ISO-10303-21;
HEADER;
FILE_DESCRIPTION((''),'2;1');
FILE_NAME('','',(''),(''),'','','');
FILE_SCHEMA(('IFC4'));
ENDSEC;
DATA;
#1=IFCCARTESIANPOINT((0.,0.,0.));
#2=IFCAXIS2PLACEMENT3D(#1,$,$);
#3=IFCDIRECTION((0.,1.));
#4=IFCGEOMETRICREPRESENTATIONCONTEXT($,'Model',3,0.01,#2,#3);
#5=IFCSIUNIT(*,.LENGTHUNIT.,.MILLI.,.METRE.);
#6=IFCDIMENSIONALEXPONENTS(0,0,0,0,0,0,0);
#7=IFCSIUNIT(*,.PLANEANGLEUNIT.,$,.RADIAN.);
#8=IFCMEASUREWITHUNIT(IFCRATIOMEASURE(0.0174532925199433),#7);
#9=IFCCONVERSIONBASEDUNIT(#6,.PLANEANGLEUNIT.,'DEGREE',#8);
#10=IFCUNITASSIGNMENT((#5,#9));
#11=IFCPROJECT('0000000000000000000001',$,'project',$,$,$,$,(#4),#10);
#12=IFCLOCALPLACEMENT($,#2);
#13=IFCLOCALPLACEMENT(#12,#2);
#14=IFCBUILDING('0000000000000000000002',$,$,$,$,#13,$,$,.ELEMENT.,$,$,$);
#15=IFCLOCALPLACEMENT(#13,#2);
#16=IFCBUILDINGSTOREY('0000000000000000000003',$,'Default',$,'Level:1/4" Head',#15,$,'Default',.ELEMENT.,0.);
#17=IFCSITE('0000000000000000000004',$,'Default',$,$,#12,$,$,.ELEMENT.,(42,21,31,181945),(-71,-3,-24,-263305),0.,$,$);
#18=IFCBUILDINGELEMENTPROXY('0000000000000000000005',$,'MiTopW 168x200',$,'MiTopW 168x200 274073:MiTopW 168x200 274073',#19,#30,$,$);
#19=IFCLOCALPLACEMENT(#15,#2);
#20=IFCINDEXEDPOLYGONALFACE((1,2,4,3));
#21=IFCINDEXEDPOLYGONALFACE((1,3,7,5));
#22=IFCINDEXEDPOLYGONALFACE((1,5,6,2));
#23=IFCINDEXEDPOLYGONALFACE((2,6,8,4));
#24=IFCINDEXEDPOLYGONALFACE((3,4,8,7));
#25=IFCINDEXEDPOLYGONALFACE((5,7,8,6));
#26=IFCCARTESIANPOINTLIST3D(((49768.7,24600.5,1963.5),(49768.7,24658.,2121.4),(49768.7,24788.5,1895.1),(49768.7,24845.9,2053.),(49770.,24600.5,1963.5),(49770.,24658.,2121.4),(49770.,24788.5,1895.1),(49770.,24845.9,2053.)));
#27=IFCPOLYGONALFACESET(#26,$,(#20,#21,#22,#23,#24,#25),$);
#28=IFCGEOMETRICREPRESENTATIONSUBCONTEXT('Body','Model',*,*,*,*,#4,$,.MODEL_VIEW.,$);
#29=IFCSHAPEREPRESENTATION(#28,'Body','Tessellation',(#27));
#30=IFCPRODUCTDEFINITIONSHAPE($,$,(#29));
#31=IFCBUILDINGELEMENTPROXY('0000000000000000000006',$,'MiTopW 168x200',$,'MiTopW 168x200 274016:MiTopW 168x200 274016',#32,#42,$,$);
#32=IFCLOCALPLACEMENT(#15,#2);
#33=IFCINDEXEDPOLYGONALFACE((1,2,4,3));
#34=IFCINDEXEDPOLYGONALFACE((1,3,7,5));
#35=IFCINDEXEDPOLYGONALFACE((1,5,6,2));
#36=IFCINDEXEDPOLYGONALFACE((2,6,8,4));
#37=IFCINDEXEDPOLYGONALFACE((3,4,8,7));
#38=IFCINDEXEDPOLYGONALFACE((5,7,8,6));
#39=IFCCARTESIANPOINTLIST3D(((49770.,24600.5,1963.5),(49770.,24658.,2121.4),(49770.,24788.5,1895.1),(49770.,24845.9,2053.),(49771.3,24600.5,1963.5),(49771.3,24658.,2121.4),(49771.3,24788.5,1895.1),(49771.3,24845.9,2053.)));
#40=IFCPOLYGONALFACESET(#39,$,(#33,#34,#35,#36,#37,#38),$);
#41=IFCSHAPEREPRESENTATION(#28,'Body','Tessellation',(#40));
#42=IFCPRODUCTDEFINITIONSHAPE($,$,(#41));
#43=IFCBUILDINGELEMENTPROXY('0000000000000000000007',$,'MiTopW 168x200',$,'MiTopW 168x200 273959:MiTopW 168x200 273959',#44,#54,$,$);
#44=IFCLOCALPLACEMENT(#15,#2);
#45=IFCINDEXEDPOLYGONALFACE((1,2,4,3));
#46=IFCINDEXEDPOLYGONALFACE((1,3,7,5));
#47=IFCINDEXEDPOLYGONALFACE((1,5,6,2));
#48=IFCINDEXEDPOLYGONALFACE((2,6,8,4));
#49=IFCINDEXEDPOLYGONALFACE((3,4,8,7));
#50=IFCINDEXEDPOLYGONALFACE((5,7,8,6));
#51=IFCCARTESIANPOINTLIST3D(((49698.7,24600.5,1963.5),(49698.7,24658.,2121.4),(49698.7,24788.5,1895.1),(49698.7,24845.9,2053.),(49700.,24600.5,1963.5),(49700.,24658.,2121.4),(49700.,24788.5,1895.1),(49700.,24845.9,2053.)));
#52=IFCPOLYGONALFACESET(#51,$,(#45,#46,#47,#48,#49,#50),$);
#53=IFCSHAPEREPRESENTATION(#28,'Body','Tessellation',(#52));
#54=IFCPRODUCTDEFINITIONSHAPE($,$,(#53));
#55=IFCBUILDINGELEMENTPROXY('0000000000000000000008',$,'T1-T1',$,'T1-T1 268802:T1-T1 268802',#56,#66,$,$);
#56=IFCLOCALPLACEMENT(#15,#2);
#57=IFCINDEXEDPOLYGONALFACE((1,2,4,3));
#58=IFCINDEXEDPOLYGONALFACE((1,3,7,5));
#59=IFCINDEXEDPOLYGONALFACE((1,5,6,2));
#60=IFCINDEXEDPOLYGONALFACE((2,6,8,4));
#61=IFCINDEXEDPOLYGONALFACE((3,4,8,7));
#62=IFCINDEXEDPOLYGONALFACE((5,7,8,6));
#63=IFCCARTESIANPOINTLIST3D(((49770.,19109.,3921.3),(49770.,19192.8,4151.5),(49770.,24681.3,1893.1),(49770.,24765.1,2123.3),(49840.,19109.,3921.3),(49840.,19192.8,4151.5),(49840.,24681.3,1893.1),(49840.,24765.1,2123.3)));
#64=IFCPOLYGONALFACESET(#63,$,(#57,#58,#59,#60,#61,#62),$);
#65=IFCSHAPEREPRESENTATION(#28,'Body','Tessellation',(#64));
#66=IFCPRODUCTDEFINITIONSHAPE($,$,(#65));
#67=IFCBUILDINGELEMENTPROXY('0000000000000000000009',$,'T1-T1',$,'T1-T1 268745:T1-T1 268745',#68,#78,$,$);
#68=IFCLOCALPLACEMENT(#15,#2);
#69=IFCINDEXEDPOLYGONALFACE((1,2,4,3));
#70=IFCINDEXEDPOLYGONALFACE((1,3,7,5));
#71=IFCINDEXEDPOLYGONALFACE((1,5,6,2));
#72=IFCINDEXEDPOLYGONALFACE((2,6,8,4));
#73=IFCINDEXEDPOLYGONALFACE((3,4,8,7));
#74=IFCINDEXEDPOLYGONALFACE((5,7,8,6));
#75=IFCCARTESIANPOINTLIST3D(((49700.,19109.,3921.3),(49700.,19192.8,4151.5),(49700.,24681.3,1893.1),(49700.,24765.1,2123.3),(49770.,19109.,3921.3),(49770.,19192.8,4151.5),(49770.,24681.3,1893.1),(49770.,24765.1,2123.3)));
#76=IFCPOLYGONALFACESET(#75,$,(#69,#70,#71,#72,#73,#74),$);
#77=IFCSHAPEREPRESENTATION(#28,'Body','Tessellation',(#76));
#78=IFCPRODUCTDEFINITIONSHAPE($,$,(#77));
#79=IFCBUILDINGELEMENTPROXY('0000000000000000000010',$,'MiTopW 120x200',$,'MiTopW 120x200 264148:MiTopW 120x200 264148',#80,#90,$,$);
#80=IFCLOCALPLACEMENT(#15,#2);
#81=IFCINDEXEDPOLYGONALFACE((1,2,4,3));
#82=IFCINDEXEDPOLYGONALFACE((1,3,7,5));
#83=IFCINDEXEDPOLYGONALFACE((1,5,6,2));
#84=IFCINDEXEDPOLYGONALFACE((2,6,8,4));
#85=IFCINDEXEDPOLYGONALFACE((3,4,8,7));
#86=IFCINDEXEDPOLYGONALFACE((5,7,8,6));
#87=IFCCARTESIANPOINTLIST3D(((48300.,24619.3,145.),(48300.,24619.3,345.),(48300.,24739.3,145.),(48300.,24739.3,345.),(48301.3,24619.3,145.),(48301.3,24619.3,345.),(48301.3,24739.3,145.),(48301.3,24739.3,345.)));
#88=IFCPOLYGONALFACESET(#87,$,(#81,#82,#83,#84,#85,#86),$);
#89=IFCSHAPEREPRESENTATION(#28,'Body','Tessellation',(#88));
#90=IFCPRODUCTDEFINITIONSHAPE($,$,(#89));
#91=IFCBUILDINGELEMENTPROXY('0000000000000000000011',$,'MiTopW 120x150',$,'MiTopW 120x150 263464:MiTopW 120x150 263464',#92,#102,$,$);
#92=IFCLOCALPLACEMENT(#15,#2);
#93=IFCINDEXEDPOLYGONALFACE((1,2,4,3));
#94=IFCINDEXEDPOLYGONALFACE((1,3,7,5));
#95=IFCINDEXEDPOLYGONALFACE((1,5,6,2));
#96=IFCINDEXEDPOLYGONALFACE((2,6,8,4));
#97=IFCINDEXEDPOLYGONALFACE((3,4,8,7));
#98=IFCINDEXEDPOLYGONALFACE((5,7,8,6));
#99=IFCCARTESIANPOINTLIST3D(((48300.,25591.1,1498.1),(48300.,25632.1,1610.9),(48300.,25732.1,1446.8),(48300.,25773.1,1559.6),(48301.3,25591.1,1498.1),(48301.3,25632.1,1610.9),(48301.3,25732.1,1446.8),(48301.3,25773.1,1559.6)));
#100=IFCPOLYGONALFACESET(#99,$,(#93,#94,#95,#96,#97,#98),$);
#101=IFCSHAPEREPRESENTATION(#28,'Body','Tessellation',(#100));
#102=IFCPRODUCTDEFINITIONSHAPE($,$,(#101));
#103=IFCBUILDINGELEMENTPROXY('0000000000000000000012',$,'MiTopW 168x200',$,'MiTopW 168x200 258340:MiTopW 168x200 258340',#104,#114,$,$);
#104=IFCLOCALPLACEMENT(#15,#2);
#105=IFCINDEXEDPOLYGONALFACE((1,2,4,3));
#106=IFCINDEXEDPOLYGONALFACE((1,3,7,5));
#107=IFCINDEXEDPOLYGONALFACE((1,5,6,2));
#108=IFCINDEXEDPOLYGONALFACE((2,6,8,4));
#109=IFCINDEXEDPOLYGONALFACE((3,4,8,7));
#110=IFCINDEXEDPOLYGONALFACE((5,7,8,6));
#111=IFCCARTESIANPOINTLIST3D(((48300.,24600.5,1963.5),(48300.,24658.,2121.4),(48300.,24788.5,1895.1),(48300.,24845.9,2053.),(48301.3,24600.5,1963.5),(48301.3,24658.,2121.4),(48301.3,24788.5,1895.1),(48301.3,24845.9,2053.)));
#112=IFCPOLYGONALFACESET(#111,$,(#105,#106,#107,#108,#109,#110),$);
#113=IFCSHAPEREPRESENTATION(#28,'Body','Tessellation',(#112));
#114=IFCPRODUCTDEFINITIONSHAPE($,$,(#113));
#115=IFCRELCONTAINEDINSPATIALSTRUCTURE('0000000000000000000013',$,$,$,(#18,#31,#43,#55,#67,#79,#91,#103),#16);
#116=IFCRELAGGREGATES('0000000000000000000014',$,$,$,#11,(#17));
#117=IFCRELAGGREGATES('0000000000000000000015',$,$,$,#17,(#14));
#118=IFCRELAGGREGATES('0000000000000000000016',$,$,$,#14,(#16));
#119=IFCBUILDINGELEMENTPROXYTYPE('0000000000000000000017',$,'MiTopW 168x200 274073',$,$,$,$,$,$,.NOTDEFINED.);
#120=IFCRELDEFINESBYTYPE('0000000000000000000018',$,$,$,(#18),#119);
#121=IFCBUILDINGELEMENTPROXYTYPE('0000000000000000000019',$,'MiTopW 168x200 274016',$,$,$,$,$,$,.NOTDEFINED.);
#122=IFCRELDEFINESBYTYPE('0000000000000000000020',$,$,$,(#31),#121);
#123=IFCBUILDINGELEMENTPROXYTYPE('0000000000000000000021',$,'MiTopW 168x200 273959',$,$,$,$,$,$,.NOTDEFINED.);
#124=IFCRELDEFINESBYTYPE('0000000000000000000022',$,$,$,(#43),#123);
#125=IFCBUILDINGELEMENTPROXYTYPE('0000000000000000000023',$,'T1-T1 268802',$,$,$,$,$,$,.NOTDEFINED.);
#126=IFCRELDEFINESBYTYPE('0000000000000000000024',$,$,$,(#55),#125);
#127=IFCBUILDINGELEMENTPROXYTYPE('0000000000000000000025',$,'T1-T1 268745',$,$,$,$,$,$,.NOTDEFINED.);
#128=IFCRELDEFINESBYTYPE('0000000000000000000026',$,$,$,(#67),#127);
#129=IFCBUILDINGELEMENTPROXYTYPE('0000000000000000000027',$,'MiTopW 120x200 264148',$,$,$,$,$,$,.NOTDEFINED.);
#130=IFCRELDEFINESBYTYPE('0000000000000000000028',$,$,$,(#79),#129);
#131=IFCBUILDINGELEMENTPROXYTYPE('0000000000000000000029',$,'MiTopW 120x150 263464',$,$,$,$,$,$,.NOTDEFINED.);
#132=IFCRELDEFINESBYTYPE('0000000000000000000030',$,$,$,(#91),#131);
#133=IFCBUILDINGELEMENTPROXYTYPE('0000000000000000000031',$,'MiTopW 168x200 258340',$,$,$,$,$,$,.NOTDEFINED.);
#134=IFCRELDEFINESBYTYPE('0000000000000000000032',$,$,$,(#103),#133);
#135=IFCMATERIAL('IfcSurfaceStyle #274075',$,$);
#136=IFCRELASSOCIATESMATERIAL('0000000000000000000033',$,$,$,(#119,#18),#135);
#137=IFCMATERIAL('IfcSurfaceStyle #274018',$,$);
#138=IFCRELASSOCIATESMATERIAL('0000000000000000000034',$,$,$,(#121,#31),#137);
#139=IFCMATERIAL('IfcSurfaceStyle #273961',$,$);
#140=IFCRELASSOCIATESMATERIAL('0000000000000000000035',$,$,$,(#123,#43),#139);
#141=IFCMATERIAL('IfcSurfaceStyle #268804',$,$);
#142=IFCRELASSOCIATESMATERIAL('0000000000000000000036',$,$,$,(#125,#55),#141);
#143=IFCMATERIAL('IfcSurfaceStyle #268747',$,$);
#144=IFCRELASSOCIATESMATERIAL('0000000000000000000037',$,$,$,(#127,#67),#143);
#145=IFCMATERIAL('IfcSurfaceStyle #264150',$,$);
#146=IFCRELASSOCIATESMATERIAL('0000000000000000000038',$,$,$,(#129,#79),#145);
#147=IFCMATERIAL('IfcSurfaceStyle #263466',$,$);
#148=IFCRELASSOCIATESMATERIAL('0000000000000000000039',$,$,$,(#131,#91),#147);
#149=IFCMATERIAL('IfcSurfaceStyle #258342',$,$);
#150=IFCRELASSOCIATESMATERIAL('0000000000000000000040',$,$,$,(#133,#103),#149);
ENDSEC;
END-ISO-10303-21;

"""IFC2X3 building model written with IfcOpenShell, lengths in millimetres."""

from ifc_helpers import new_model, entity, si_unit, converted_unit, direction, frame, origin, origin_2d_with_axis, place, context, subcontext, project, spatial, polyline, rectangle, outline, extrude, source, transform, mapped, material, type_object, type_shapes, element, save


model = new_model("IFC2X3")

# Units and contexts
model_context = context("Model", 3, precision=0.01, world=origin(), true_north=direction((0.0, 1.0)))
body_context = subcontext(model_context, "Body", "Model", "MODEL_VIEW")
ifc_project = project(units=[si_unit("LENGTHUNIT", "METRE", prefix="MILLI"), converted_unit("PLANEANGLEUNIT", "DEGREE", entity("IfcRatioMeasure", 0.0174532925199433), si_unit("PLANEANGLEUNIT", "RADIAN"), dimensions=[0, 0, 0, 0, 0, 0, 0])], contexts=[model_context])

# Site, building, storey
site_placement = place(None, origin())
site = spatial("IfcSite", under=ifc_project, at=site_placement, Name="Default", CompositionType="ELEMENT", RefLatitude=(42, 21, 31, 181945), RefLongitude=(-71, -3, -24, -263305), RefElevation=0.0)
building_placement = place(site_placement, origin())
building = spatial("IfcBuilding", under=site, at=building_placement, CompositionType="ELEMENT")
storey_placement = place(building_placement, origin())
storey = spatial("IfcBuildingStorey", under=building, at=storey_placement, Name="Default", ObjectType="Level:1/4\" Head", LongName="Default", CompositionType="ELEMENT", Elevation=0.0)

# Building element proxies
ifc_material_1 = material(Name="IfcSurfaceStyle #274075")
building_element_proxy_type_1 = type_object("IfcBuildingElementProxyType", Name="MiTopW 168x200 274073", PredefinedType="NOTDEFINED", material=ifc_material_1)
shared_shape_1 = source(origin(), body_context, "Body", "SweptSolid", [
    extrude(outline(polyline([(-100.0, -84.0), (100.0, -84.0), (100.0, 84.0), (-100.0, 84.0), (-100.0, -84.0)])), frame((100.0, 84.0, 0.0), z_axis=(0.0, 0.0, 1.0), x_axis=(-1.0, 0.0, 0.0)), (0.0, 0.0, 1.0), 1.3),
])
type_shapes(building_element_proxy_type_1, [shared_shape_1])
proxy_1_placement = place(building_placement, frame((49770.0, 24788.5, 1895.1), z_axis=(-1.0, 0.0, 0.0), x_axis=(0.0, -0.939693, 0.34202)))
element("IfcBuildingElementProxy", 1, at=proxy_1_placement, inside=storey, type_object=building_element_proxy_type_1, material=ifc_material_1, Name="MiTopW 168x200", ObjectType="MiTopW 168x200 274073:MiTopW 168x200 274073", context=body_context, shape_type="MappedRepresentation", body=[
    mapped(shared_shape_1, transform((0.0, 0.0, 0.0), scale=1.0)),
])
ifc_material_2 = material(Name="IfcSurfaceStyle #274018")
building_element_proxy_type_2 = type_object("IfcBuildingElementProxyType", Name="MiTopW 168x200 274016", PredefinedType="NOTDEFINED", material=ifc_material_2)
shared_shape_2 = source(origin(), body_context, "Body", "SweptSolid", [
    extrude(outline(polyline([(-100.0, -84.0), (100.0, -84.0), (100.0, 84.0), (-100.0, 84.0), (-100.0, -84.0)])), frame((100.0, 84.0, 0.0), z_axis=(0.0, 0.0, 1.0), x_axis=(-1.0, 0.0, 0.0)), (0.0, 0.0, 1.0), 1.3),
])
type_shapes(building_element_proxy_type_2, [shared_shape_2])
proxy_2_placement = place(building_placement, frame((49771.3, 24788.5, 1895.1), z_axis=(-1.0, 0.0, 0.0), x_axis=(0.0, -0.939693, 0.34202)))
element("IfcBuildingElementProxy", 2, at=proxy_2_placement, inside=storey, type_object=building_element_proxy_type_2, material=ifc_material_2, Name="MiTopW 168x200", ObjectType="MiTopW 168x200 274016:MiTopW 168x200 274016", context=body_context, shape_type="MappedRepresentation", body=[
    mapped(shared_shape_2, transform((0.0, 0.0, 0.0), scale=1.0)),
])
ifc_material_3 = material(Name="IfcSurfaceStyle #273961")
building_element_proxy_type_3 = type_object("IfcBuildingElementProxyType", Name="MiTopW 168x200 273959", PredefinedType="NOTDEFINED", material=ifc_material_3)
shared_shape_3 = source(origin(), body_context, "Body", "SweptSolid", [
    extrude(outline(polyline([(-100.0, -84.0), (100.0, -84.0), (100.0, 84.0), (-100.0, 84.0), (-100.0, -84.0)])), frame((100.0, 84.0, 0.0), z_axis=(0.0, 0.0, 1.0), x_axis=(-1.0, 0.0, 0.0)), (0.0, 0.0, 1.0), 1.3),
])
type_shapes(building_element_proxy_type_3, [shared_shape_3])
proxy_3_placement = place(building_placement, frame((49700.0, 24788.5, 1895.1), z_axis=(-1.0, 0.0, 0.0), x_axis=(0.0, -0.939693, 0.34202)))
element("IfcBuildingElementProxy", 3, at=proxy_3_placement, inside=storey, type_object=building_element_proxy_type_3, material=ifc_material_3, Name="MiTopW 168x200", ObjectType="MiTopW 168x200 273959:MiTopW 168x200 273959", context=body_context, shape_type="MappedRepresentation", body=[
    mapped(shared_shape_3, transform((0.0, 0.0, 0.0), scale=1.0)),
])
ifc_material_4 = material(Name="IfcSurfaceStyle #268804")
building_element_proxy_type_4 = type_object("IfcBuildingElementProxyType", Name="T1-T1 268802", PredefinedType="NOTDEFINED", material=ifc_material_4)
shared_shape_4 = source(origin(), body_context, "Body", "SweptSolid", [
    extrude(outline(polyline([(-2965.0, -122.5), (2965.0, -122.5), (2965.0, 122.5), (-2965.0, 122.5), (-2965.0, -122.5)])), frame((2965.0, 122.5, 0.0), z_axis=(0.0, 0.0, 1.0), x_axis=(-1.0, 0.0, 0.0)), (0.0, 0.0, 1.0), 70.0),
])
type_shapes(building_element_proxy_type_4, [shared_shape_4])
proxy_4_placement = place(building_placement, frame((49840.0, 24681.3, 1893.1), z_axis=(-1.0, 0.0, 0.0), x_axis=(0.0, -0.939693, 0.34202)))
element("IfcBuildingElementProxy", 4, at=proxy_4_placement, inside=storey, type_object=building_element_proxy_type_4, material=ifc_material_4, Name="T1-T1", ObjectType="T1-T1 268802:T1-T1 268802", context=body_context, shape_type="MappedRepresentation", body=[
    mapped(shared_shape_4, transform((0.0, 0.0, 0.0), scale=1.0)),
])
ifc_material_5 = material(Name="IfcSurfaceStyle #268747")
building_element_proxy_type_5 = type_object("IfcBuildingElementProxyType", Name="T1-T1 268745", PredefinedType="NOTDEFINED", material=ifc_material_5)
shared_shape_5 = source(origin(), body_context, "Body", "SweptSolid", [
    extrude(outline(polyline([(-2965.0, -122.5), (2965.0, -122.5), (2965.0, 122.5), (-2965.0, 122.5), (-2965.0, -122.5)])), frame((2965.0, 122.5, 0.0), z_axis=(0.0, 0.0, 1.0), x_axis=(-1.0, 0.0, 0.0)), (0.0, 0.0, 1.0), 70.0),
])
type_shapes(building_element_proxy_type_5, [shared_shape_5])
proxy_5_placement = place(building_placement, frame((49770.0, 24681.3, 1893.1), z_axis=(-1.0, 0.0, 0.0), x_axis=(0.0, -0.939693, 0.34202)))
element("IfcBuildingElementProxy", 5, at=proxy_5_placement, inside=storey, type_object=building_element_proxy_type_5, material=ifc_material_5, Name="T1-T1", ObjectType="T1-T1 268745:T1-T1 268745", context=body_context, shape_type="MappedRepresentation", body=[
    mapped(shared_shape_5, transform((0.0, 0.0, 0.0), scale=1.0)),
])
ifc_material_6 = material(Name="IfcSurfaceStyle #264150")
building_element_proxy_type_6 = type_object("IfcBuildingElementProxyType", Name="MiTopW 120x200 264148", PredefinedType="NOTDEFINED", material=ifc_material_6)
shared_shape_6 = source(origin(), body_context, "Body", "SweptSolid", [
    extrude(rectangle(XDim=200.0, YDim=120.0, at=origin_2d_with_axis()), frame((100.0, 60.0, 0.0), z_axis=(0.0, 0.0, 1.0), x_axis=(-1.0, 0.0, 0.0)), (0.0, 0.0, 1.0), 1.3),
])
type_shapes(building_element_proxy_type_6, [shared_shape_6])
proxy_6_placement = place(building_placement, frame((48301.3, 24619.3, 145.0), z_axis=(-1.0, 0.0, 0.0), x_axis=(0.0, 0.0, 1.0)))
element("IfcBuildingElementProxy", 6, at=proxy_6_placement, inside=storey, type_object=building_element_proxy_type_6, material=ifc_material_6, Name="MiTopW 120x200", ObjectType="MiTopW 120x200 264148:MiTopW 120x200 264148", context=body_context, shape_type="MappedRepresentation", body=[
    mapped(shared_shape_6, transform((0.0, 0.0, 0.0), scale=1.0)),
])
ifc_material_7 = material(Name="IfcSurfaceStyle #263466")
building_element_proxy_type_7 = type_object("IfcBuildingElementProxyType", Name="MiTopW 120x150 263464", PredefinedType="NOTDEFINED", material=ifc_material_7)
shared_shape_7 = source(origin(), body_context, "Body", "SweptSolid", [
    extrude(outline(polyline([(-75.0, -60.0), (75.0, -60.0), (75.0, 60.0), (-75.0, 60.0), (-75.0, -60.0)])), frame((75.0, 60.0, 0.0), z_axis=(0.0, 0.0, 1.0), x_axis=(-1.0, 0.0, 0.0)), (0.0, 0.0, 1.0), 1.3),
])
type_shapes(building_element_proxy_type_7, [shared_shape_7])
proxy_7_placement = place(building_placement, frame((48301.3, 25732.1, 1446.8), z_axis=(-1.0, 0.0, 0.0), x_axis=(0.0, -0.939693, 0.34202)))
element("IfcBuildingElementProxy", 7, at=proxy_7_placement, inside=storey, type_object=building_element_proxy_type_7, material=ifc_material_7, Name="MiTopW 120x150", ObjectType="MiTopW 120x150 263464:MiTopW 120x150 263464", context=body_context, shape_type="MappedRepresentation", body=[
    mapped(shared_shape_7, transform((0.0, 0.0, 0.0), scale=1.0)),
])
ifc_material_8 = material(Name="IfcSurfaceStyle #258342")
building_element_proxy_type_8 = type_object("IfcBuildingElementProxyType", Name="MiTopW 168x200 258340", PredefinedType="NOTDEFINED", material=ifc_material_8)
shared_shape_8 = source(origin(), body_context, "Body", "SweptSolid", [
    extrude(outline(polyline([(-100.0, -84.0), (100.0, -84.0), (100.0, 84.0), (-100.0, 84.0), (-100.0, -84.0)])), frame((100.0, 84.0, 0.0), z_axis=(0.0, 0.0, 1.0), x_axis=(-1.0, 0.0, 0.0)), (0.0, 0.0, 1.0), 1.3),
])
type_shapes(building_element_proxy_type_8, [shared_shape_8])
proxy_8_placement = place(building_placement, frame((48301.3, 24788.5, 1895.1), z_axis=(-1.0, 0.0, 0.0), x_axis=(0.0, -0.939693, 0.34202)))
element("IfcBuildingElementProxy", 8, at=proxy_8_placement, inside=storey, type_object=building_element_proxy_type_8, material=ifc_material_8, Name="MiTopW 168x200", ObjectType="MiTopW 168x200 258340:MiTopW 168x200 258340", context=body_context, shape_type="MappedRepresentation", body=[
    mapped(shared_shape_8, transform((0.0, 0.0, 0.0), scale=1.0)),
])

save(model, "model.ifc")
